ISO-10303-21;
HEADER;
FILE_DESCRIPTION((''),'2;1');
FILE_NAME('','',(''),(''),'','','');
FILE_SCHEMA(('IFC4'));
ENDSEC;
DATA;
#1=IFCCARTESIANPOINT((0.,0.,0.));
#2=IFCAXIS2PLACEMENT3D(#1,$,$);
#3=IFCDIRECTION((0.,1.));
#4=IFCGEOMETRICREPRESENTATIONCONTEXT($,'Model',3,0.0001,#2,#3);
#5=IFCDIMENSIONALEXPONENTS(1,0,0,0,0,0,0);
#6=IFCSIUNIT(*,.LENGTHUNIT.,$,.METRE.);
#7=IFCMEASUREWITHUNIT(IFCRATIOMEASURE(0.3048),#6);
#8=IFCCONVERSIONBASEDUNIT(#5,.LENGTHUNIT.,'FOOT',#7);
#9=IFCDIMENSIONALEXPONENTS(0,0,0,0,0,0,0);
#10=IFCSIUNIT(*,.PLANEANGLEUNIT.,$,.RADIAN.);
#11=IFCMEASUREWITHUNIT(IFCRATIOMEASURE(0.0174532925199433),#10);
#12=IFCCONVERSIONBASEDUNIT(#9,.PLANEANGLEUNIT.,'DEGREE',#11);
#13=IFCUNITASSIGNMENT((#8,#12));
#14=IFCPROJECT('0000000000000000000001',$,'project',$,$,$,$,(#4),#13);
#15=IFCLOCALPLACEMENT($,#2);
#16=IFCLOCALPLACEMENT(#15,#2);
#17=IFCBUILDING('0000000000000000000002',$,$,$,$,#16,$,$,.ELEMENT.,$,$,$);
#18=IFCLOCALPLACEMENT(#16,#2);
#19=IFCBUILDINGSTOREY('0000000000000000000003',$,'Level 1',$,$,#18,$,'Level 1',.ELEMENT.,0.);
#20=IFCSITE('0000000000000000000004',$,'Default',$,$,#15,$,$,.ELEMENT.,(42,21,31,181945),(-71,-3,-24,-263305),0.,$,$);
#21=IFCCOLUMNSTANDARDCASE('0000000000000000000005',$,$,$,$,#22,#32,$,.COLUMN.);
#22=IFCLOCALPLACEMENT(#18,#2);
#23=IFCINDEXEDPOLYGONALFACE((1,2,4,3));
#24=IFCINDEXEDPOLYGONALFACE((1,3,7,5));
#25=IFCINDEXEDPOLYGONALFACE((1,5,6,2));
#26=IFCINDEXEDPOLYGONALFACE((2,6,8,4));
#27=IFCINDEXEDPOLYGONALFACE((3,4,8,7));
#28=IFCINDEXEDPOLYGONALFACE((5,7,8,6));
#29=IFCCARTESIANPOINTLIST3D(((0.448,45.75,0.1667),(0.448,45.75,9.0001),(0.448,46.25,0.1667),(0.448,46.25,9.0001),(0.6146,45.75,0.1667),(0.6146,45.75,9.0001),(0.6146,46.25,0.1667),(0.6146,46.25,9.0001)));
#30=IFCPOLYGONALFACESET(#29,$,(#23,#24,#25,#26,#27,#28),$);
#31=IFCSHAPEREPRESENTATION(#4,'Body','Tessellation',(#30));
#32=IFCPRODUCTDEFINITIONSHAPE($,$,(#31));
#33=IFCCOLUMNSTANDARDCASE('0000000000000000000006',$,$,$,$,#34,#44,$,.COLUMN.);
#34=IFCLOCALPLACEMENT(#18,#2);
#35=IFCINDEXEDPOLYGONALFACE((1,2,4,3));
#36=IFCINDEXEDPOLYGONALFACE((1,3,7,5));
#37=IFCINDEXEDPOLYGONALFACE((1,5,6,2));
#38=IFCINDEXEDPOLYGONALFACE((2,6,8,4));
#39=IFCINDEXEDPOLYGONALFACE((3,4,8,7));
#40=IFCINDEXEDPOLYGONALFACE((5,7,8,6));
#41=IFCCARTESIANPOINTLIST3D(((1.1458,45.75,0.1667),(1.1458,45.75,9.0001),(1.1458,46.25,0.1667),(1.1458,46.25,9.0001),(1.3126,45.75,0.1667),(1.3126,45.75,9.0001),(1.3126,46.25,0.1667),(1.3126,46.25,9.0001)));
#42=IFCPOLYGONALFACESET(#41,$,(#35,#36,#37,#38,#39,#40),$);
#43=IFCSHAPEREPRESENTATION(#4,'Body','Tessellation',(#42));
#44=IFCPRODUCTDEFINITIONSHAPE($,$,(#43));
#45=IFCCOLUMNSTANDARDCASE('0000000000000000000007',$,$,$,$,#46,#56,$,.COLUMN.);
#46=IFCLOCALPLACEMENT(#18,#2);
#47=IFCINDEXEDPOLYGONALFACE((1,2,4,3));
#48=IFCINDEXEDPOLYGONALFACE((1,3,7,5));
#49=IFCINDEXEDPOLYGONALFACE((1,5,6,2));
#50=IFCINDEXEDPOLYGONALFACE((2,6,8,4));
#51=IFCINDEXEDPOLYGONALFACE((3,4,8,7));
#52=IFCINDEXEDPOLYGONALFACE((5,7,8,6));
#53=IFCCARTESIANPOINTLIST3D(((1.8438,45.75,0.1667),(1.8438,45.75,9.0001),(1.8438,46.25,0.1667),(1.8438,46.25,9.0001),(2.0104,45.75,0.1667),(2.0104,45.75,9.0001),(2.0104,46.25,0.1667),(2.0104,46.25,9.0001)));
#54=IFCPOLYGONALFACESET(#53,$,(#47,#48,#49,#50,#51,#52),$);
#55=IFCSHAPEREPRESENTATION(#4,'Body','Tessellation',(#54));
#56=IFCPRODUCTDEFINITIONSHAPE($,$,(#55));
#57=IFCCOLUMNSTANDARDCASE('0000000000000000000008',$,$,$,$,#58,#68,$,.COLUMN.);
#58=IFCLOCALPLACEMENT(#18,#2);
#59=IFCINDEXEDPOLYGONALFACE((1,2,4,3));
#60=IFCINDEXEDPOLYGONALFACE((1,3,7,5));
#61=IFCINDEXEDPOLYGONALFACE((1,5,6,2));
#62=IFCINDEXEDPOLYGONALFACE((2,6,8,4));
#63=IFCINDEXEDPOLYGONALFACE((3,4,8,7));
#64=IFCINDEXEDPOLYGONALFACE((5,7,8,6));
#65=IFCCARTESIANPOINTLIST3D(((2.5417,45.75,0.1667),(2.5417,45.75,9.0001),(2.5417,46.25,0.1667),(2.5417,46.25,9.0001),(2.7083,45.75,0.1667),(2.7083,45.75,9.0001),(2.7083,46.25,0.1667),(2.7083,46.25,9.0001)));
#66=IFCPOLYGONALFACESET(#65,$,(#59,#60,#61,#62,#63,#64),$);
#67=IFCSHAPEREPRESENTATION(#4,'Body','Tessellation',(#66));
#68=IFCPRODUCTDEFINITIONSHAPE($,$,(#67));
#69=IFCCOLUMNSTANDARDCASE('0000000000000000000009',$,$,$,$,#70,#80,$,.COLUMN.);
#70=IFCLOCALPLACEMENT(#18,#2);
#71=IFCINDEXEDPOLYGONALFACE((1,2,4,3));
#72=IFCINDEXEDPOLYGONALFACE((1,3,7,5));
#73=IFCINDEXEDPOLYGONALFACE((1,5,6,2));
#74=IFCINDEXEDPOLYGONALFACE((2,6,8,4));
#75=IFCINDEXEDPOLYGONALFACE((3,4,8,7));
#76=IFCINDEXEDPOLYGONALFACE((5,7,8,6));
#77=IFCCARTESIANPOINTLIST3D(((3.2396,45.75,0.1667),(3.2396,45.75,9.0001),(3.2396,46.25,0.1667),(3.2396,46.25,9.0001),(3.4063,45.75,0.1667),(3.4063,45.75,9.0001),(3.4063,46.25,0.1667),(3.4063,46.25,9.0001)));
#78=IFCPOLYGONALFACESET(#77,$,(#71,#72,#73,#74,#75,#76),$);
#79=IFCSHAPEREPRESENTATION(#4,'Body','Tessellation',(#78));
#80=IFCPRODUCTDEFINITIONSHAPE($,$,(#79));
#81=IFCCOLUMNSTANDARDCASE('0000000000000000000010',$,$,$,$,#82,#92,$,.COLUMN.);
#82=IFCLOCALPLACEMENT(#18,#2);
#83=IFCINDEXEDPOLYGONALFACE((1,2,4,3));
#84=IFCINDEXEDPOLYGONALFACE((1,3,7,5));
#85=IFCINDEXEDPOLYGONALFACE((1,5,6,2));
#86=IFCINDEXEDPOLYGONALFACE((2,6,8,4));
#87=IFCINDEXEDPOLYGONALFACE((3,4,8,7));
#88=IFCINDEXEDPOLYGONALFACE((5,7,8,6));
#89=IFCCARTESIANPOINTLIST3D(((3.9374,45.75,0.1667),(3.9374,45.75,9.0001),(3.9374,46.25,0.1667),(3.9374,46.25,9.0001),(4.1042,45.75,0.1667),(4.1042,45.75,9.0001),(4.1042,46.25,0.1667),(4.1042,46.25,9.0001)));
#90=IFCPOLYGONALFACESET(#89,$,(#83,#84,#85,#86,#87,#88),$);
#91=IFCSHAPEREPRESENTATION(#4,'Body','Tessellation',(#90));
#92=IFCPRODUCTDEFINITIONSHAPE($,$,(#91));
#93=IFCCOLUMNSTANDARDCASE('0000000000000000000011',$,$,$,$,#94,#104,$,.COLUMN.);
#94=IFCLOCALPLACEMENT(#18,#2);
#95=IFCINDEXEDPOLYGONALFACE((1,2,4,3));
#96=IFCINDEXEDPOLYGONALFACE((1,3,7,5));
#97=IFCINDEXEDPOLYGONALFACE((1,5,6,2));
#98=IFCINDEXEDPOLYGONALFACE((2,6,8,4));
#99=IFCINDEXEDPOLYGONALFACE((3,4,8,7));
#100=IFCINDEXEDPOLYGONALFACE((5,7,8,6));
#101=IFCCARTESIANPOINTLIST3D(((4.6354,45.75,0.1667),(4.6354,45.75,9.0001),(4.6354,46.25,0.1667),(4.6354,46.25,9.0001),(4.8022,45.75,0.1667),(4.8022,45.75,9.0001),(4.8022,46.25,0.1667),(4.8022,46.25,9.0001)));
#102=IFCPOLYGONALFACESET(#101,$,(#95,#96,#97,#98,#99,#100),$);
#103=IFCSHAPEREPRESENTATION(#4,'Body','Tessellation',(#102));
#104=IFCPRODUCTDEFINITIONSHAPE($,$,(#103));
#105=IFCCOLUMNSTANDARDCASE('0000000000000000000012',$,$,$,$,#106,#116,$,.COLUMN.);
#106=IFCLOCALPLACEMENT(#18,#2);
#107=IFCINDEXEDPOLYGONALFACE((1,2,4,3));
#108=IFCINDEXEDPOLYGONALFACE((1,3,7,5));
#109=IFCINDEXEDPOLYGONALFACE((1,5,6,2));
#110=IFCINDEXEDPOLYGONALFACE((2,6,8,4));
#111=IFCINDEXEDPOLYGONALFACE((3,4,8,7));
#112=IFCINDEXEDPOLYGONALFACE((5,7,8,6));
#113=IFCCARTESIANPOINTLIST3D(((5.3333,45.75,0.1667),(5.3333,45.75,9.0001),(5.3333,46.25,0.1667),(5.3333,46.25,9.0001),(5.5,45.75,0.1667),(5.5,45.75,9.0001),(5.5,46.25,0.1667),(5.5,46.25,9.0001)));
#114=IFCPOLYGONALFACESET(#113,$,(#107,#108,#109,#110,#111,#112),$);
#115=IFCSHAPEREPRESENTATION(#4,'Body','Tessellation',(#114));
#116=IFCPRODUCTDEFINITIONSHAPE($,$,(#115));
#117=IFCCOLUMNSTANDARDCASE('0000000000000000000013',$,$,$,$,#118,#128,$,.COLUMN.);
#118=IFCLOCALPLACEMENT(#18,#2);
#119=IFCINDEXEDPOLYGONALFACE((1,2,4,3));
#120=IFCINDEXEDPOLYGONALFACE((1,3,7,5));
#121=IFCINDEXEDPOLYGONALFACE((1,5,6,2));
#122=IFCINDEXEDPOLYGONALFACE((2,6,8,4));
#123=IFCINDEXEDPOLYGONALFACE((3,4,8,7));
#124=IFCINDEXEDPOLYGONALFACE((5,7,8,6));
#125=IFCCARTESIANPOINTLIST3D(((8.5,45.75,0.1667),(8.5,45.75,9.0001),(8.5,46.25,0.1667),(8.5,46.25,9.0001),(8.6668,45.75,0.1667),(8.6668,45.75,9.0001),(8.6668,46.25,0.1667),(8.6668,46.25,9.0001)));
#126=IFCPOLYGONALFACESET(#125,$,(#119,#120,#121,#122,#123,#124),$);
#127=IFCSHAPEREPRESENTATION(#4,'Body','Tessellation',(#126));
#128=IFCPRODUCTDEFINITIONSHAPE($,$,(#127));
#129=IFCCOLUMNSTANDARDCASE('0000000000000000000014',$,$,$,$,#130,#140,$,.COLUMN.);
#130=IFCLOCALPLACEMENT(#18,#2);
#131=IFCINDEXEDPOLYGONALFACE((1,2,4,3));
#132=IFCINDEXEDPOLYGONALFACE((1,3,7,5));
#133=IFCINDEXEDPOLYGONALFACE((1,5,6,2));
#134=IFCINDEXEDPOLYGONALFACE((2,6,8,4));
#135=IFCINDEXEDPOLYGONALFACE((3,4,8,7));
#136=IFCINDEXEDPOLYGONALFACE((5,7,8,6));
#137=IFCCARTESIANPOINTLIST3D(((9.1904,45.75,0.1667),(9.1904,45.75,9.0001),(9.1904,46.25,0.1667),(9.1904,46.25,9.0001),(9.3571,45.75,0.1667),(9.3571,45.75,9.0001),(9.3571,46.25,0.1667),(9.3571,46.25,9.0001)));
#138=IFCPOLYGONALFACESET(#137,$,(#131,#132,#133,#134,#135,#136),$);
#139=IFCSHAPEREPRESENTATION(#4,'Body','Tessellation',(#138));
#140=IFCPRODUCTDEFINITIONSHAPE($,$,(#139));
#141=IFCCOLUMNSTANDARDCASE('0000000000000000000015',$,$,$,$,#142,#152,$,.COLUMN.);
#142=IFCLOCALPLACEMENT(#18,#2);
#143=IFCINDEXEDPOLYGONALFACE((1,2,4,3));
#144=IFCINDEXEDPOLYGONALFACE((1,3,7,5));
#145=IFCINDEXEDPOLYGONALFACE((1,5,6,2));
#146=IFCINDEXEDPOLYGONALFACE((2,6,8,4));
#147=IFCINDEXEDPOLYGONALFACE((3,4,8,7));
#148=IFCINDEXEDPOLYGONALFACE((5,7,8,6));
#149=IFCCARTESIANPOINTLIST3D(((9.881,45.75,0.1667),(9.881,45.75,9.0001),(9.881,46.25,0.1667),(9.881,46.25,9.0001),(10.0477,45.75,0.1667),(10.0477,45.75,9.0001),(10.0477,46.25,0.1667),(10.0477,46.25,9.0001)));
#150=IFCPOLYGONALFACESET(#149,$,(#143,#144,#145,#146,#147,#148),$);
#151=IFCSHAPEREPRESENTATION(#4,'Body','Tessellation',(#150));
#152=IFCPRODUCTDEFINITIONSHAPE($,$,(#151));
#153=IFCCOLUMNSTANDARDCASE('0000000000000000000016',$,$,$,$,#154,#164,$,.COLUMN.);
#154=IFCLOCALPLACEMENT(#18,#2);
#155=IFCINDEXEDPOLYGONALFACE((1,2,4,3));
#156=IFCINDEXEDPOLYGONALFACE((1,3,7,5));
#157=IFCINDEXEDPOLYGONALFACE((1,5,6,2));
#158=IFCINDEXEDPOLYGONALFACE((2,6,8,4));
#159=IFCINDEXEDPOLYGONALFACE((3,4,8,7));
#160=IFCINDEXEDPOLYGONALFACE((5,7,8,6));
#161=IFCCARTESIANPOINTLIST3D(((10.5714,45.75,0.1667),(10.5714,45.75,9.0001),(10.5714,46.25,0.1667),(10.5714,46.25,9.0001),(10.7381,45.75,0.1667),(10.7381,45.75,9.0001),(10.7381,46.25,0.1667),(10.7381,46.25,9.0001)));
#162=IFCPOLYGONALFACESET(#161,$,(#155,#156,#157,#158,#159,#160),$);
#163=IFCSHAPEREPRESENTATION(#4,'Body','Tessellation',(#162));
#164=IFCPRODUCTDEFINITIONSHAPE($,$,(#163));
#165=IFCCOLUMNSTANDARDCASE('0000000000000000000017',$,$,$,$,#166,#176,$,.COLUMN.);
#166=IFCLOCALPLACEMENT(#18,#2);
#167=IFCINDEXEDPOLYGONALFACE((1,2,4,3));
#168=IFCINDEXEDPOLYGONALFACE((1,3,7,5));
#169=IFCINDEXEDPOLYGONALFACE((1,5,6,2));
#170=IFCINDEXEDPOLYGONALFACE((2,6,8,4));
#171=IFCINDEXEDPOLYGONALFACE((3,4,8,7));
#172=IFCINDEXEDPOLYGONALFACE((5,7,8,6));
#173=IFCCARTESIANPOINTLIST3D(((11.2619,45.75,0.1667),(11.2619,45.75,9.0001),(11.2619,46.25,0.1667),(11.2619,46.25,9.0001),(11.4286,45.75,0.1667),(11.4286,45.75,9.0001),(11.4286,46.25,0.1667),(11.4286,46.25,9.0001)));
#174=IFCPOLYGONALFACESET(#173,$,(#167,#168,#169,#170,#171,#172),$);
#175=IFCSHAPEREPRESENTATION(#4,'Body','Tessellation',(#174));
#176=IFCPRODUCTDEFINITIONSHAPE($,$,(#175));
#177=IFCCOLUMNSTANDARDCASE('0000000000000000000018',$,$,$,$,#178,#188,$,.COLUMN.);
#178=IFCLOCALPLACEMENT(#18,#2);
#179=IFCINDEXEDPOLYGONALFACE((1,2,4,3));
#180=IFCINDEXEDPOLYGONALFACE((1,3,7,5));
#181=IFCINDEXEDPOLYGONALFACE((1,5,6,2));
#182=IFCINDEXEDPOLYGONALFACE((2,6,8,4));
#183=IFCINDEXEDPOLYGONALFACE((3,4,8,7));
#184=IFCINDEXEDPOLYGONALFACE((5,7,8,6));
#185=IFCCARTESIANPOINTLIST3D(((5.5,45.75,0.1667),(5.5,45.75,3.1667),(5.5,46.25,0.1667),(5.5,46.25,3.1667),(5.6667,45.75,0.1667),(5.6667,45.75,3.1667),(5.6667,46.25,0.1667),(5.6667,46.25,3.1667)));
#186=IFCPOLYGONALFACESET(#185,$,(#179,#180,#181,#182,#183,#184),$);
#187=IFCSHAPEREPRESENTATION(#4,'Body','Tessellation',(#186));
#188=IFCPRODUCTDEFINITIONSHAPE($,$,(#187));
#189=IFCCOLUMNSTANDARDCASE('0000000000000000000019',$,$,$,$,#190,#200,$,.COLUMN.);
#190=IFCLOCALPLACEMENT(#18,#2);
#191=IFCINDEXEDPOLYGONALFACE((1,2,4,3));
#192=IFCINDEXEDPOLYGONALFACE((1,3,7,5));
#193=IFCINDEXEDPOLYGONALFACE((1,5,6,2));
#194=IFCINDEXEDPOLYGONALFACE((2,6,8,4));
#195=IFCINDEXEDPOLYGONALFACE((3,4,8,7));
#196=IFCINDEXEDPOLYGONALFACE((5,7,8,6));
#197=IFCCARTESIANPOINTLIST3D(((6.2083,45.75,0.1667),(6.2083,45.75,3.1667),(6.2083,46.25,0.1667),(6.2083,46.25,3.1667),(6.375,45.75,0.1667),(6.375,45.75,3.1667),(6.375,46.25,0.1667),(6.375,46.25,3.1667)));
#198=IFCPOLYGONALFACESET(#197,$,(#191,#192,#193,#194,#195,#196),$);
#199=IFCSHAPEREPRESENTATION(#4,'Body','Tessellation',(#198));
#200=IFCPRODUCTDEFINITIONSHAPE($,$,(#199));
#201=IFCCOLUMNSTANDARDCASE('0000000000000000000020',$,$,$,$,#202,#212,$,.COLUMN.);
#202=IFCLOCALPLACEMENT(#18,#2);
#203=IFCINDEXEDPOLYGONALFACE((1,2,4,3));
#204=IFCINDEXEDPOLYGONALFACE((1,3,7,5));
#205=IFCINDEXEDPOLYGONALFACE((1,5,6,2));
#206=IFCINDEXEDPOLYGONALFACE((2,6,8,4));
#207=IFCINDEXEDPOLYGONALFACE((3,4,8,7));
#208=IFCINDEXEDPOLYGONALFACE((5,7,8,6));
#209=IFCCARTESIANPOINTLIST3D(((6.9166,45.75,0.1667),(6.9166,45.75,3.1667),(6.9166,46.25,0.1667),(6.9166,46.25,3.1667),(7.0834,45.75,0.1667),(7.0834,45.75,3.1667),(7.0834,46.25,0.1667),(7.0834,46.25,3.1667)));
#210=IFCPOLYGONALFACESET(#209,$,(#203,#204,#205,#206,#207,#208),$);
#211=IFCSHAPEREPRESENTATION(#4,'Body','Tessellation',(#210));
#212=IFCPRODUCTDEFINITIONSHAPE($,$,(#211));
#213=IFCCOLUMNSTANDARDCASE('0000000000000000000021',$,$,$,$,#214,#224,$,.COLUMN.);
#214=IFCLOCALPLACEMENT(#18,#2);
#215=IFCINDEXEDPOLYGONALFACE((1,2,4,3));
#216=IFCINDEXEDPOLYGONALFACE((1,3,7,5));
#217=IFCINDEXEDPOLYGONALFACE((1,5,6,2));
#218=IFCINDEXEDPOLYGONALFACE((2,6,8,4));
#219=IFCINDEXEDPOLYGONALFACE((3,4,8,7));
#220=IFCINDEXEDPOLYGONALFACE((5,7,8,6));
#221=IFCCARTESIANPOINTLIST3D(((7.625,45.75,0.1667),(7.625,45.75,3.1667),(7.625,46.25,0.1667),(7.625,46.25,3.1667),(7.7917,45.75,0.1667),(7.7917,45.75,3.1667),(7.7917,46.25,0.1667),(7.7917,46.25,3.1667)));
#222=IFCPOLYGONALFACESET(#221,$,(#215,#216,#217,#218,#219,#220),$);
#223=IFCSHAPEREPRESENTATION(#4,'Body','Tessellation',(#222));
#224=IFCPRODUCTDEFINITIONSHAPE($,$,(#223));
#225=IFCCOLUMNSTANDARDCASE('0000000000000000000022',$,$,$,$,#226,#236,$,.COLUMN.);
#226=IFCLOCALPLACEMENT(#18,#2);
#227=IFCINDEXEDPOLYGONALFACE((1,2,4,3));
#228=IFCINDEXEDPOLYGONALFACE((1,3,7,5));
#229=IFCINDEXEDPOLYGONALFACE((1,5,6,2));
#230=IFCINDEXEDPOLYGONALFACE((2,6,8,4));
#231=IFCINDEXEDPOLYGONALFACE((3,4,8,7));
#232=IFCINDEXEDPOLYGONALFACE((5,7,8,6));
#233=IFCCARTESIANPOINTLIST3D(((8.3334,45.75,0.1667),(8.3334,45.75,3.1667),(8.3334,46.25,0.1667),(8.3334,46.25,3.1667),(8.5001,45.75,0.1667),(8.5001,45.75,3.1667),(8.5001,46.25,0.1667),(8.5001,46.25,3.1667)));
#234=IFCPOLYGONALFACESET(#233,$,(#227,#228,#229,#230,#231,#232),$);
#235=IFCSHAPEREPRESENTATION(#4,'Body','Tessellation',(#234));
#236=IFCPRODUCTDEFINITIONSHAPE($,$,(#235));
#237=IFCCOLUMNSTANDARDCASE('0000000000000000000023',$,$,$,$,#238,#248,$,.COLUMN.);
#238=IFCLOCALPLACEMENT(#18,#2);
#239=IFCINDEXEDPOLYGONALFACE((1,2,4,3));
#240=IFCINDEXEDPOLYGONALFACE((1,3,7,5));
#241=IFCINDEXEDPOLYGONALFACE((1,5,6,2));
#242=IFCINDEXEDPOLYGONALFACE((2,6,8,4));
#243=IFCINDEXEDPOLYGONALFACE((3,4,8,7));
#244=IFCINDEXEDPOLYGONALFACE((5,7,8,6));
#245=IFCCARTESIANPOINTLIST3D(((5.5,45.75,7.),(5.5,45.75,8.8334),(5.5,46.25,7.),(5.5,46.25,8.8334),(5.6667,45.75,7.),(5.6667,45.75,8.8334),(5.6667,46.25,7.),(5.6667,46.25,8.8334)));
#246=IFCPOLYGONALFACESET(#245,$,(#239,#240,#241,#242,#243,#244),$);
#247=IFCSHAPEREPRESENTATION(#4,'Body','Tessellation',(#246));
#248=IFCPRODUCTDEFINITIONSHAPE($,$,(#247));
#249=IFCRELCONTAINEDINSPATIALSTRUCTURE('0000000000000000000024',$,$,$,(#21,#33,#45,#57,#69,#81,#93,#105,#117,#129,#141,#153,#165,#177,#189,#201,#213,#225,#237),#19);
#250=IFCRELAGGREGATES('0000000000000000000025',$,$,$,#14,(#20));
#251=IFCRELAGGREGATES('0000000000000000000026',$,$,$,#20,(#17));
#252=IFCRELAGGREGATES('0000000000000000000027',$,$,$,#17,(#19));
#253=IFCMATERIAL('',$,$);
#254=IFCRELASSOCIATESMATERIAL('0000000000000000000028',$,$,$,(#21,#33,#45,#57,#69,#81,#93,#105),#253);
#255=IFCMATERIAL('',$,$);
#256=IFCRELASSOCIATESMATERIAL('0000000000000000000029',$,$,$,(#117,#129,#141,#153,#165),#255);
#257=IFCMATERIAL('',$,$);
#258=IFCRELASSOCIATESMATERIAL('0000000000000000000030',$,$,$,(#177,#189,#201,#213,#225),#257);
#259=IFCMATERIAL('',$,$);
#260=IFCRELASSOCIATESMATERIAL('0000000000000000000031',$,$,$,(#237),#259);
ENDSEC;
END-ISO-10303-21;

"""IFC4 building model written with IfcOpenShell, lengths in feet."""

from ifc_helpers import new_model, entity, si_unit, converted_unit, direction, frame, origin, place, context, project, spatial, rectangle, extrude, material, element, save


model = new_model("IFC4")

# Units and contexts
model_context = context("Model", 3, precision=0.0001, world=origin(), true_north=direction((0.0, 1.0)))
ifc_project = project(units=[converted_unit("LENGTHUNIT", "FOOT", entity("IfcRatioMeasure", 0.3048), si_unit("LENGTHUNIT", "METRE"), dimensions=[1, 0, 0, 0, 0, 0, 0]), converted_unit("PLANEANGLEUNIT", "DEGREE", entity("IfcRatioMeasure", 0.0174532925199433), si_unit("PLANEANGLEUNIT", "RADIAN"), dimensions=[0, 0, 0, 0, 0, 0, 0])], contexts=[model_context])

# Site, building, storey
site_placement = place(None, origin())
site = spatial("IfcSite", under=ifc_project, at=site_placement, Name="Default", CompositionType="ELEMENT", RefLatitude=(42, 21, 31, 181945), RefLongitude=(-71, -3, -24, -263305), RefElevation=0.0)
building_placement = place(site_placement, origin())
building = spatial("IfcBuilding", under=site, at=building_placement, CompositionType="ELEMENT")
storey_placement = place(building_placement, origin())
storey = spatial("IfcBuildingStorey", under=building, at=storey_placement, Name="Level 1", LongName="Level 1", CompositionType="ELEMENT", Elevation=0.0)

# Columns
ifc_material_1 = material(Name="")
placement_1 = place(storey_placement, frame((-0.25, 46.0, 0.0)))
for number, where, z_axis, x_axis in (
    (1, (0.7813, 0.0, 0.1667), (0.0, 0.0, 1.0), (1.0, 0.0, 0.0)),
    (2, (1.4792, 0.0, 0.1667), (0.0, 0.0, 1.0), (1.0, 0.0, 0.0)),
    (3, (2.1771, 0.0, 0.1667), (0.0, 0.0, 1.0), (1.0, 0.0, 0.0)),
    (4, (2.875, 0.0, 0.1667), (0.0, 0.0, 1.0), (1.0, 0.0, 0.0)),
    (5, (3.5729, 0.0, 0.1667), (0.0, 0.0, 1.0), (1.0, 0.0, 0.0)),
    (6, (4.2708, 0.0, 0.1667), (0.0, 0.0, 1.0), (1.0, 0.0, 0.0)),
    (7, (4.9688, 0.0, 0.1667), (0.0, 0.0, 1.0), (1.0, 0.0, 0.0)),
    (8, (5.6667, 0.0, 0.1667), (0.0, 0.0, 1.0), (1.0, 0.0, 0.0)),
):
    element("IfcColumnStandardCase", number, at=place(placement_1, frame(where, z_axis=z_axis, x_axis=x_axis)), inside=storey, material=ifc_material_1, PredefinedType="COLUMN", context=model_context, shape_type="SweptSolid", body=[
        extrude(rectangle(XDim=0.1667, YDim=0.5), origin(), (0.0, 0.0, 1.0), 8.8334),
    ])
ifc_material_2 = material(Name="")
for number, where, z_axis, x_axis in (
    (9, (8.8334, 0.0, 0.1667), (0.0, 0.0, 1.0), (1.0, 0.0, 0.0)),
    (10, (9.5238, 0.0, 0.1667), (0.0, 0.0, 1.0), (1.0, 0.0, 0.0)),
    (11, (10.2143, 0.0, 0.1667), (0.0, 0.0, 1.0), (1.0, 0.0, 0.0)),
    (12, (10.9048, 0.0, 0.1667), (0.0, 0.0, 1.0), (1.0, 0.0, 0.0)),
    (13, (11.5953, 0.0, 0.1667), (0.0, 0.0, 1.0), (1.0, 0.0, 0.0)),
):
    element("IfcColumnStandardCase", number, at=place(placement_1, frame(where, z_axis=z_axis, x_axis=x_axis)), inside=storey, material=ifc_material_2, PredefinedType="COLUMN", context=model_context, shape_type="SweptSolid", body=[
        extrude(rectangle(XDim=0.1667, YDim=0.5), origin(), (0.0, 0.0, 1.0), 8.8334),
    ])
ifc_material_3 = material(Name="")
for number, where, z_axis, x_axis in (
    (14, (5.8333, 0.0, 0.1667), (0.0, 0.0, 1.0), (1.0, 0.0, 0.0)),
    (15, (6.5417, 0.0, 0.1667), (0.0, 0.0, 1.0), (1.0, 0.0, 0.0)),
    (16, (7.25, 0.0, 0.1667), (0.0, 0.0, 1.0), (1.0, 0.0, 0.0)),
    (17, (7.9583, 0.0, 0.1667), (0.0, 0.0, 1.0), (1.0, 0.0, 0.0)),
    (18, (8.6667, 0.0, 0.1667), (0.0, 0.0, 1.0), (1.0, 0.0, 0.0)),
):
    element("IfcColumnStandardCase", number, at=place(placement_1, frame(where, z_axis=z_axis, x_axis=x_axis)), inside=storey, material=ifc_material_3, PredefinedType="COLUMN", context=model_context, shape_type="SweptSolid", body=[
        extrude(rectangle(XDim=0.1667, YDim=0.5), origin(), (0.0, 0.0, 1.0), 3.0),
    ])
ifc_material_4 = material(Name="")
for number, where, z_axis, x_axis in (
    (19, (5.8333, 0.0, 7.0), (0.0, 0.0, 1.0), (1.0, 0.0, 0.0)),
):
    element("IfcColumnStandardCase", number, at=place(placement_1, frame(where, z_axis=z_axis, x_axis=x_axis)), inside=storey, material=ifc_material_4, PredefinedType="COLUMN", context=model_context, shape_type="SweptSolid", body=[
        extrude(rectangle(XDim=0.1667, YDim=0.5), origin(), (0.0, 0.0, 1.0), 1.8334),
    ])

save(model, "model.ifc")
